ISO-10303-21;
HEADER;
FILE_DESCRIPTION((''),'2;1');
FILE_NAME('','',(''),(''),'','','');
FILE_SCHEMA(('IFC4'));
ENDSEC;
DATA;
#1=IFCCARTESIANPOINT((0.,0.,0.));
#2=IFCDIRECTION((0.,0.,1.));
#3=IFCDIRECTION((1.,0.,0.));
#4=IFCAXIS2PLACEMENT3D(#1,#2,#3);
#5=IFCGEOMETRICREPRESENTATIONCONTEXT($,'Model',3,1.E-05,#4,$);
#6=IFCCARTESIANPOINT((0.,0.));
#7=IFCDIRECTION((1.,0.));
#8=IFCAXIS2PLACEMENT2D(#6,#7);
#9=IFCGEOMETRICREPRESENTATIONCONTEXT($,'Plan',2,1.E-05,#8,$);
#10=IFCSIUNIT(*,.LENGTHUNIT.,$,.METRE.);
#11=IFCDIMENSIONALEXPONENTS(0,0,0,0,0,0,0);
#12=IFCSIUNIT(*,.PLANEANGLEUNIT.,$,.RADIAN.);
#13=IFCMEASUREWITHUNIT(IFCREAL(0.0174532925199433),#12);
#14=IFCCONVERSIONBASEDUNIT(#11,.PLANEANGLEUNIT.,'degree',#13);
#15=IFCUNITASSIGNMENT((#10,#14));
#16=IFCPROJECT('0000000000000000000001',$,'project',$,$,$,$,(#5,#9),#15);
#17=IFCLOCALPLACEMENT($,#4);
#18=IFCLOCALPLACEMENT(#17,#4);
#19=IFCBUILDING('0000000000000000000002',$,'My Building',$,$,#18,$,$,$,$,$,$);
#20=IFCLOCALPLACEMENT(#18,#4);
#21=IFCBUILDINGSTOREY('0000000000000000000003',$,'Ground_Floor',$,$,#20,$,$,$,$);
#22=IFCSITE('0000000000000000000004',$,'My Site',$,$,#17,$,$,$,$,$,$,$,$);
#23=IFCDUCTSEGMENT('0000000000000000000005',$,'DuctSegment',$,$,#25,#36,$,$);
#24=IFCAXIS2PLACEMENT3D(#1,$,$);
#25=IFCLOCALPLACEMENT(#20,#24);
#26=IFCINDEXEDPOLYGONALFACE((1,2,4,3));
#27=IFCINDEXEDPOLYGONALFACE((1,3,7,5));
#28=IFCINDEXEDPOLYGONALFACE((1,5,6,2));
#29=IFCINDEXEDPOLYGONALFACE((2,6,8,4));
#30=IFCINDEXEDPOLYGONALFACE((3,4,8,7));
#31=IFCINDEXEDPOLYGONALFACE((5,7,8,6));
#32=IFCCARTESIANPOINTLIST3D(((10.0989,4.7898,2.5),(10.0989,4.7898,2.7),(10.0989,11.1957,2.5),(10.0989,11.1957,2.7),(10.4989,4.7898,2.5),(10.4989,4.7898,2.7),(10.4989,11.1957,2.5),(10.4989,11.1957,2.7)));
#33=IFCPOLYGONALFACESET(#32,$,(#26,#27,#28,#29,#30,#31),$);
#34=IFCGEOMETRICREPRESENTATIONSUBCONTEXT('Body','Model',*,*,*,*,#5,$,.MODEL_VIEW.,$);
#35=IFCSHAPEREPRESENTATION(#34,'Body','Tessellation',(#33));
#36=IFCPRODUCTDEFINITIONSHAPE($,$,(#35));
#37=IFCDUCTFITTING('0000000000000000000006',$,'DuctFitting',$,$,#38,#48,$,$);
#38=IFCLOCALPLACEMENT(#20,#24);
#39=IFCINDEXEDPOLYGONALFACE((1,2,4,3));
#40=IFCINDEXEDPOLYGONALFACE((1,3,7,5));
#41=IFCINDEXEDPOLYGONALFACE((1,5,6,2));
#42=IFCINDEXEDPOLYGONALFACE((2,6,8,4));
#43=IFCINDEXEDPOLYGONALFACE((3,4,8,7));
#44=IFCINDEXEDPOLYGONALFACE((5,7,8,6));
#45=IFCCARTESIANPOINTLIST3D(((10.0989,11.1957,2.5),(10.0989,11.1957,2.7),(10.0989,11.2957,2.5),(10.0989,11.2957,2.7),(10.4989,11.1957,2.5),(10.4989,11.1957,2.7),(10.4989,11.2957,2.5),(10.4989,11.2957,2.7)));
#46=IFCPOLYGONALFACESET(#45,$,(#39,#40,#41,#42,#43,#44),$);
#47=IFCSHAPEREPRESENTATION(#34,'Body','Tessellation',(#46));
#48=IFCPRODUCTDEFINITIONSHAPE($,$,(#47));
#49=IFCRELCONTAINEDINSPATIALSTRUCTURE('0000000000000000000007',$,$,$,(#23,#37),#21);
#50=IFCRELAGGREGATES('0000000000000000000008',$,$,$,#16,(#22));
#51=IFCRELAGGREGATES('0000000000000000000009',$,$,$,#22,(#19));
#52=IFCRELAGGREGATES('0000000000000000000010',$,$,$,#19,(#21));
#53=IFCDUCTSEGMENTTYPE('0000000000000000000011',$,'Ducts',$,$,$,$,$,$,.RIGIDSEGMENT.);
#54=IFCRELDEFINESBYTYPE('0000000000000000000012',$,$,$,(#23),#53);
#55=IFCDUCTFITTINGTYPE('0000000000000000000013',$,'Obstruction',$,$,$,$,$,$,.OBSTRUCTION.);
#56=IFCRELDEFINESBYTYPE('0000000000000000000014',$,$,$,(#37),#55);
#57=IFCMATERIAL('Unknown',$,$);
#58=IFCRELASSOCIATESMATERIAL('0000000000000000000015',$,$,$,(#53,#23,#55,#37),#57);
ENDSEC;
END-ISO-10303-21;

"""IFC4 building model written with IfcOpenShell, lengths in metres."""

from ifc_helpers import new_model, entity, si_unit, converted_unit, frame, origin_with_axes, origin_2d_with_axis, place, context, subcontext, project, spatial, rectangle, extrude, material, material_profile, profile_set, profile_usage, type_object, element, save


model = new_model("IFC4")

# Units and contexts
model_context = context("Model", 3, precision=1e-05, world=origin_with_axes())
plan_context = context("Plan", 2, precision=1e-05, world=origin_2d_with_axis())
body_context = subcontext(model_context, "Body", "Model", "MODEL_VIEW")
ifc_project = project(units=[si_unit("LENGTHUNIT", "METRE"), converted_unit("PLANEANGLEUNIT", "degree", entity("IfcReal", 0.0174532925199433), si_unit("PLANEANGLEUNIT", "RADIAN"), dimensions=[0, 0, 0, 0, 0, 0, 0])], contexts=[model_context, plan_context])

# Site, building, storey
site_placement = place(None, origin_with_axes())
site = spatial("IfcSite", under=ifc_project, at=site_placement, Name="My Site")
building_placement = place(site_placement, origin_with_axes())
building = spatial("IfcBuilding", under=site, at=building_placement, Name="My Building")
storey_placement = place(building_placement, origin_with_axes())
storey = spatial("IfcBuildingStorey", under=building, at=storey_placement, Name="Ground_Floor")

# Shared definitions
ifc_material = material(Name="Unknown")

# Duct segment
ifc_material_profile_1 = material_profile(ifc_material, rectangle(XDim=0.4, YDim=0.2))
ifc_profile_set_1 = profile_set([ifc_material_profile_1])
ifc_profile_usage_1 = profile_usage(ifc_profile_set_1, cardinal=5)
duct_segment_type = type_object("IfcDuctSegmentType", Name="Ducts", PredefinedType="RIGIDSEGMENT", material=ifc_profile_set_1)
duct_segment_placement = place(storey_placement, frame((10.2989, 4.7898, 2.6), z_axis=(0.0, 1.0, 0.0), x_axis=(-1.0, 0.0, 0.0)))
element("IfcDuctSegment", 1, at=duct_segment_placement, inside=storey, type_object=duct_segment_type, material=ifc_profile_usage_1, Name="DuctSegment", context=body_context, shape_type="SweptSolid", body=[
    extrude(rectangle(XDim=0.4, YDim=0.2), origin_with_axes(), (0.0, 0.0, 1.0), 6.4059),
])

# Duct fitting
ifc_material_profile_2 = material_profile(ifc_material, rectangle(XDim=0.4, YDim=0.2))
ifc_profile_set_2 = profile_set([ifc_material_profile_2])
ifc_profile_usage_2 = profile_usage(ifc_profile_set_2, cardinal=5)
duct_fitting_type = type_object("IfcDuctFittingType", Name="Obstruction", PredefinedType="OBSTRUCTION", material=ifc_profile_set_2)
duct_fitting_placement = place(storey_placement, frame((10.2989, 11.1957, 2.6), z_axis=(0.0, 1.0, 0.0), x_axis=(-1.0, 0.0, 0.0)))
element("IfcDuctFitting", 2, at=duct_fitting_placement, inside=storey, type_object=duct_fitting_type, material=ifc_profile_usage_2, Name="DuctFitting", context=body_context, shape_type="SweptSolid", body=[
    extrude(rectangle(XDim=0.4, YDim=0.2), origin_with_axes(), (0.0, 0.0, 1.0), 0.1),
])

save(model, "model.ifc")
